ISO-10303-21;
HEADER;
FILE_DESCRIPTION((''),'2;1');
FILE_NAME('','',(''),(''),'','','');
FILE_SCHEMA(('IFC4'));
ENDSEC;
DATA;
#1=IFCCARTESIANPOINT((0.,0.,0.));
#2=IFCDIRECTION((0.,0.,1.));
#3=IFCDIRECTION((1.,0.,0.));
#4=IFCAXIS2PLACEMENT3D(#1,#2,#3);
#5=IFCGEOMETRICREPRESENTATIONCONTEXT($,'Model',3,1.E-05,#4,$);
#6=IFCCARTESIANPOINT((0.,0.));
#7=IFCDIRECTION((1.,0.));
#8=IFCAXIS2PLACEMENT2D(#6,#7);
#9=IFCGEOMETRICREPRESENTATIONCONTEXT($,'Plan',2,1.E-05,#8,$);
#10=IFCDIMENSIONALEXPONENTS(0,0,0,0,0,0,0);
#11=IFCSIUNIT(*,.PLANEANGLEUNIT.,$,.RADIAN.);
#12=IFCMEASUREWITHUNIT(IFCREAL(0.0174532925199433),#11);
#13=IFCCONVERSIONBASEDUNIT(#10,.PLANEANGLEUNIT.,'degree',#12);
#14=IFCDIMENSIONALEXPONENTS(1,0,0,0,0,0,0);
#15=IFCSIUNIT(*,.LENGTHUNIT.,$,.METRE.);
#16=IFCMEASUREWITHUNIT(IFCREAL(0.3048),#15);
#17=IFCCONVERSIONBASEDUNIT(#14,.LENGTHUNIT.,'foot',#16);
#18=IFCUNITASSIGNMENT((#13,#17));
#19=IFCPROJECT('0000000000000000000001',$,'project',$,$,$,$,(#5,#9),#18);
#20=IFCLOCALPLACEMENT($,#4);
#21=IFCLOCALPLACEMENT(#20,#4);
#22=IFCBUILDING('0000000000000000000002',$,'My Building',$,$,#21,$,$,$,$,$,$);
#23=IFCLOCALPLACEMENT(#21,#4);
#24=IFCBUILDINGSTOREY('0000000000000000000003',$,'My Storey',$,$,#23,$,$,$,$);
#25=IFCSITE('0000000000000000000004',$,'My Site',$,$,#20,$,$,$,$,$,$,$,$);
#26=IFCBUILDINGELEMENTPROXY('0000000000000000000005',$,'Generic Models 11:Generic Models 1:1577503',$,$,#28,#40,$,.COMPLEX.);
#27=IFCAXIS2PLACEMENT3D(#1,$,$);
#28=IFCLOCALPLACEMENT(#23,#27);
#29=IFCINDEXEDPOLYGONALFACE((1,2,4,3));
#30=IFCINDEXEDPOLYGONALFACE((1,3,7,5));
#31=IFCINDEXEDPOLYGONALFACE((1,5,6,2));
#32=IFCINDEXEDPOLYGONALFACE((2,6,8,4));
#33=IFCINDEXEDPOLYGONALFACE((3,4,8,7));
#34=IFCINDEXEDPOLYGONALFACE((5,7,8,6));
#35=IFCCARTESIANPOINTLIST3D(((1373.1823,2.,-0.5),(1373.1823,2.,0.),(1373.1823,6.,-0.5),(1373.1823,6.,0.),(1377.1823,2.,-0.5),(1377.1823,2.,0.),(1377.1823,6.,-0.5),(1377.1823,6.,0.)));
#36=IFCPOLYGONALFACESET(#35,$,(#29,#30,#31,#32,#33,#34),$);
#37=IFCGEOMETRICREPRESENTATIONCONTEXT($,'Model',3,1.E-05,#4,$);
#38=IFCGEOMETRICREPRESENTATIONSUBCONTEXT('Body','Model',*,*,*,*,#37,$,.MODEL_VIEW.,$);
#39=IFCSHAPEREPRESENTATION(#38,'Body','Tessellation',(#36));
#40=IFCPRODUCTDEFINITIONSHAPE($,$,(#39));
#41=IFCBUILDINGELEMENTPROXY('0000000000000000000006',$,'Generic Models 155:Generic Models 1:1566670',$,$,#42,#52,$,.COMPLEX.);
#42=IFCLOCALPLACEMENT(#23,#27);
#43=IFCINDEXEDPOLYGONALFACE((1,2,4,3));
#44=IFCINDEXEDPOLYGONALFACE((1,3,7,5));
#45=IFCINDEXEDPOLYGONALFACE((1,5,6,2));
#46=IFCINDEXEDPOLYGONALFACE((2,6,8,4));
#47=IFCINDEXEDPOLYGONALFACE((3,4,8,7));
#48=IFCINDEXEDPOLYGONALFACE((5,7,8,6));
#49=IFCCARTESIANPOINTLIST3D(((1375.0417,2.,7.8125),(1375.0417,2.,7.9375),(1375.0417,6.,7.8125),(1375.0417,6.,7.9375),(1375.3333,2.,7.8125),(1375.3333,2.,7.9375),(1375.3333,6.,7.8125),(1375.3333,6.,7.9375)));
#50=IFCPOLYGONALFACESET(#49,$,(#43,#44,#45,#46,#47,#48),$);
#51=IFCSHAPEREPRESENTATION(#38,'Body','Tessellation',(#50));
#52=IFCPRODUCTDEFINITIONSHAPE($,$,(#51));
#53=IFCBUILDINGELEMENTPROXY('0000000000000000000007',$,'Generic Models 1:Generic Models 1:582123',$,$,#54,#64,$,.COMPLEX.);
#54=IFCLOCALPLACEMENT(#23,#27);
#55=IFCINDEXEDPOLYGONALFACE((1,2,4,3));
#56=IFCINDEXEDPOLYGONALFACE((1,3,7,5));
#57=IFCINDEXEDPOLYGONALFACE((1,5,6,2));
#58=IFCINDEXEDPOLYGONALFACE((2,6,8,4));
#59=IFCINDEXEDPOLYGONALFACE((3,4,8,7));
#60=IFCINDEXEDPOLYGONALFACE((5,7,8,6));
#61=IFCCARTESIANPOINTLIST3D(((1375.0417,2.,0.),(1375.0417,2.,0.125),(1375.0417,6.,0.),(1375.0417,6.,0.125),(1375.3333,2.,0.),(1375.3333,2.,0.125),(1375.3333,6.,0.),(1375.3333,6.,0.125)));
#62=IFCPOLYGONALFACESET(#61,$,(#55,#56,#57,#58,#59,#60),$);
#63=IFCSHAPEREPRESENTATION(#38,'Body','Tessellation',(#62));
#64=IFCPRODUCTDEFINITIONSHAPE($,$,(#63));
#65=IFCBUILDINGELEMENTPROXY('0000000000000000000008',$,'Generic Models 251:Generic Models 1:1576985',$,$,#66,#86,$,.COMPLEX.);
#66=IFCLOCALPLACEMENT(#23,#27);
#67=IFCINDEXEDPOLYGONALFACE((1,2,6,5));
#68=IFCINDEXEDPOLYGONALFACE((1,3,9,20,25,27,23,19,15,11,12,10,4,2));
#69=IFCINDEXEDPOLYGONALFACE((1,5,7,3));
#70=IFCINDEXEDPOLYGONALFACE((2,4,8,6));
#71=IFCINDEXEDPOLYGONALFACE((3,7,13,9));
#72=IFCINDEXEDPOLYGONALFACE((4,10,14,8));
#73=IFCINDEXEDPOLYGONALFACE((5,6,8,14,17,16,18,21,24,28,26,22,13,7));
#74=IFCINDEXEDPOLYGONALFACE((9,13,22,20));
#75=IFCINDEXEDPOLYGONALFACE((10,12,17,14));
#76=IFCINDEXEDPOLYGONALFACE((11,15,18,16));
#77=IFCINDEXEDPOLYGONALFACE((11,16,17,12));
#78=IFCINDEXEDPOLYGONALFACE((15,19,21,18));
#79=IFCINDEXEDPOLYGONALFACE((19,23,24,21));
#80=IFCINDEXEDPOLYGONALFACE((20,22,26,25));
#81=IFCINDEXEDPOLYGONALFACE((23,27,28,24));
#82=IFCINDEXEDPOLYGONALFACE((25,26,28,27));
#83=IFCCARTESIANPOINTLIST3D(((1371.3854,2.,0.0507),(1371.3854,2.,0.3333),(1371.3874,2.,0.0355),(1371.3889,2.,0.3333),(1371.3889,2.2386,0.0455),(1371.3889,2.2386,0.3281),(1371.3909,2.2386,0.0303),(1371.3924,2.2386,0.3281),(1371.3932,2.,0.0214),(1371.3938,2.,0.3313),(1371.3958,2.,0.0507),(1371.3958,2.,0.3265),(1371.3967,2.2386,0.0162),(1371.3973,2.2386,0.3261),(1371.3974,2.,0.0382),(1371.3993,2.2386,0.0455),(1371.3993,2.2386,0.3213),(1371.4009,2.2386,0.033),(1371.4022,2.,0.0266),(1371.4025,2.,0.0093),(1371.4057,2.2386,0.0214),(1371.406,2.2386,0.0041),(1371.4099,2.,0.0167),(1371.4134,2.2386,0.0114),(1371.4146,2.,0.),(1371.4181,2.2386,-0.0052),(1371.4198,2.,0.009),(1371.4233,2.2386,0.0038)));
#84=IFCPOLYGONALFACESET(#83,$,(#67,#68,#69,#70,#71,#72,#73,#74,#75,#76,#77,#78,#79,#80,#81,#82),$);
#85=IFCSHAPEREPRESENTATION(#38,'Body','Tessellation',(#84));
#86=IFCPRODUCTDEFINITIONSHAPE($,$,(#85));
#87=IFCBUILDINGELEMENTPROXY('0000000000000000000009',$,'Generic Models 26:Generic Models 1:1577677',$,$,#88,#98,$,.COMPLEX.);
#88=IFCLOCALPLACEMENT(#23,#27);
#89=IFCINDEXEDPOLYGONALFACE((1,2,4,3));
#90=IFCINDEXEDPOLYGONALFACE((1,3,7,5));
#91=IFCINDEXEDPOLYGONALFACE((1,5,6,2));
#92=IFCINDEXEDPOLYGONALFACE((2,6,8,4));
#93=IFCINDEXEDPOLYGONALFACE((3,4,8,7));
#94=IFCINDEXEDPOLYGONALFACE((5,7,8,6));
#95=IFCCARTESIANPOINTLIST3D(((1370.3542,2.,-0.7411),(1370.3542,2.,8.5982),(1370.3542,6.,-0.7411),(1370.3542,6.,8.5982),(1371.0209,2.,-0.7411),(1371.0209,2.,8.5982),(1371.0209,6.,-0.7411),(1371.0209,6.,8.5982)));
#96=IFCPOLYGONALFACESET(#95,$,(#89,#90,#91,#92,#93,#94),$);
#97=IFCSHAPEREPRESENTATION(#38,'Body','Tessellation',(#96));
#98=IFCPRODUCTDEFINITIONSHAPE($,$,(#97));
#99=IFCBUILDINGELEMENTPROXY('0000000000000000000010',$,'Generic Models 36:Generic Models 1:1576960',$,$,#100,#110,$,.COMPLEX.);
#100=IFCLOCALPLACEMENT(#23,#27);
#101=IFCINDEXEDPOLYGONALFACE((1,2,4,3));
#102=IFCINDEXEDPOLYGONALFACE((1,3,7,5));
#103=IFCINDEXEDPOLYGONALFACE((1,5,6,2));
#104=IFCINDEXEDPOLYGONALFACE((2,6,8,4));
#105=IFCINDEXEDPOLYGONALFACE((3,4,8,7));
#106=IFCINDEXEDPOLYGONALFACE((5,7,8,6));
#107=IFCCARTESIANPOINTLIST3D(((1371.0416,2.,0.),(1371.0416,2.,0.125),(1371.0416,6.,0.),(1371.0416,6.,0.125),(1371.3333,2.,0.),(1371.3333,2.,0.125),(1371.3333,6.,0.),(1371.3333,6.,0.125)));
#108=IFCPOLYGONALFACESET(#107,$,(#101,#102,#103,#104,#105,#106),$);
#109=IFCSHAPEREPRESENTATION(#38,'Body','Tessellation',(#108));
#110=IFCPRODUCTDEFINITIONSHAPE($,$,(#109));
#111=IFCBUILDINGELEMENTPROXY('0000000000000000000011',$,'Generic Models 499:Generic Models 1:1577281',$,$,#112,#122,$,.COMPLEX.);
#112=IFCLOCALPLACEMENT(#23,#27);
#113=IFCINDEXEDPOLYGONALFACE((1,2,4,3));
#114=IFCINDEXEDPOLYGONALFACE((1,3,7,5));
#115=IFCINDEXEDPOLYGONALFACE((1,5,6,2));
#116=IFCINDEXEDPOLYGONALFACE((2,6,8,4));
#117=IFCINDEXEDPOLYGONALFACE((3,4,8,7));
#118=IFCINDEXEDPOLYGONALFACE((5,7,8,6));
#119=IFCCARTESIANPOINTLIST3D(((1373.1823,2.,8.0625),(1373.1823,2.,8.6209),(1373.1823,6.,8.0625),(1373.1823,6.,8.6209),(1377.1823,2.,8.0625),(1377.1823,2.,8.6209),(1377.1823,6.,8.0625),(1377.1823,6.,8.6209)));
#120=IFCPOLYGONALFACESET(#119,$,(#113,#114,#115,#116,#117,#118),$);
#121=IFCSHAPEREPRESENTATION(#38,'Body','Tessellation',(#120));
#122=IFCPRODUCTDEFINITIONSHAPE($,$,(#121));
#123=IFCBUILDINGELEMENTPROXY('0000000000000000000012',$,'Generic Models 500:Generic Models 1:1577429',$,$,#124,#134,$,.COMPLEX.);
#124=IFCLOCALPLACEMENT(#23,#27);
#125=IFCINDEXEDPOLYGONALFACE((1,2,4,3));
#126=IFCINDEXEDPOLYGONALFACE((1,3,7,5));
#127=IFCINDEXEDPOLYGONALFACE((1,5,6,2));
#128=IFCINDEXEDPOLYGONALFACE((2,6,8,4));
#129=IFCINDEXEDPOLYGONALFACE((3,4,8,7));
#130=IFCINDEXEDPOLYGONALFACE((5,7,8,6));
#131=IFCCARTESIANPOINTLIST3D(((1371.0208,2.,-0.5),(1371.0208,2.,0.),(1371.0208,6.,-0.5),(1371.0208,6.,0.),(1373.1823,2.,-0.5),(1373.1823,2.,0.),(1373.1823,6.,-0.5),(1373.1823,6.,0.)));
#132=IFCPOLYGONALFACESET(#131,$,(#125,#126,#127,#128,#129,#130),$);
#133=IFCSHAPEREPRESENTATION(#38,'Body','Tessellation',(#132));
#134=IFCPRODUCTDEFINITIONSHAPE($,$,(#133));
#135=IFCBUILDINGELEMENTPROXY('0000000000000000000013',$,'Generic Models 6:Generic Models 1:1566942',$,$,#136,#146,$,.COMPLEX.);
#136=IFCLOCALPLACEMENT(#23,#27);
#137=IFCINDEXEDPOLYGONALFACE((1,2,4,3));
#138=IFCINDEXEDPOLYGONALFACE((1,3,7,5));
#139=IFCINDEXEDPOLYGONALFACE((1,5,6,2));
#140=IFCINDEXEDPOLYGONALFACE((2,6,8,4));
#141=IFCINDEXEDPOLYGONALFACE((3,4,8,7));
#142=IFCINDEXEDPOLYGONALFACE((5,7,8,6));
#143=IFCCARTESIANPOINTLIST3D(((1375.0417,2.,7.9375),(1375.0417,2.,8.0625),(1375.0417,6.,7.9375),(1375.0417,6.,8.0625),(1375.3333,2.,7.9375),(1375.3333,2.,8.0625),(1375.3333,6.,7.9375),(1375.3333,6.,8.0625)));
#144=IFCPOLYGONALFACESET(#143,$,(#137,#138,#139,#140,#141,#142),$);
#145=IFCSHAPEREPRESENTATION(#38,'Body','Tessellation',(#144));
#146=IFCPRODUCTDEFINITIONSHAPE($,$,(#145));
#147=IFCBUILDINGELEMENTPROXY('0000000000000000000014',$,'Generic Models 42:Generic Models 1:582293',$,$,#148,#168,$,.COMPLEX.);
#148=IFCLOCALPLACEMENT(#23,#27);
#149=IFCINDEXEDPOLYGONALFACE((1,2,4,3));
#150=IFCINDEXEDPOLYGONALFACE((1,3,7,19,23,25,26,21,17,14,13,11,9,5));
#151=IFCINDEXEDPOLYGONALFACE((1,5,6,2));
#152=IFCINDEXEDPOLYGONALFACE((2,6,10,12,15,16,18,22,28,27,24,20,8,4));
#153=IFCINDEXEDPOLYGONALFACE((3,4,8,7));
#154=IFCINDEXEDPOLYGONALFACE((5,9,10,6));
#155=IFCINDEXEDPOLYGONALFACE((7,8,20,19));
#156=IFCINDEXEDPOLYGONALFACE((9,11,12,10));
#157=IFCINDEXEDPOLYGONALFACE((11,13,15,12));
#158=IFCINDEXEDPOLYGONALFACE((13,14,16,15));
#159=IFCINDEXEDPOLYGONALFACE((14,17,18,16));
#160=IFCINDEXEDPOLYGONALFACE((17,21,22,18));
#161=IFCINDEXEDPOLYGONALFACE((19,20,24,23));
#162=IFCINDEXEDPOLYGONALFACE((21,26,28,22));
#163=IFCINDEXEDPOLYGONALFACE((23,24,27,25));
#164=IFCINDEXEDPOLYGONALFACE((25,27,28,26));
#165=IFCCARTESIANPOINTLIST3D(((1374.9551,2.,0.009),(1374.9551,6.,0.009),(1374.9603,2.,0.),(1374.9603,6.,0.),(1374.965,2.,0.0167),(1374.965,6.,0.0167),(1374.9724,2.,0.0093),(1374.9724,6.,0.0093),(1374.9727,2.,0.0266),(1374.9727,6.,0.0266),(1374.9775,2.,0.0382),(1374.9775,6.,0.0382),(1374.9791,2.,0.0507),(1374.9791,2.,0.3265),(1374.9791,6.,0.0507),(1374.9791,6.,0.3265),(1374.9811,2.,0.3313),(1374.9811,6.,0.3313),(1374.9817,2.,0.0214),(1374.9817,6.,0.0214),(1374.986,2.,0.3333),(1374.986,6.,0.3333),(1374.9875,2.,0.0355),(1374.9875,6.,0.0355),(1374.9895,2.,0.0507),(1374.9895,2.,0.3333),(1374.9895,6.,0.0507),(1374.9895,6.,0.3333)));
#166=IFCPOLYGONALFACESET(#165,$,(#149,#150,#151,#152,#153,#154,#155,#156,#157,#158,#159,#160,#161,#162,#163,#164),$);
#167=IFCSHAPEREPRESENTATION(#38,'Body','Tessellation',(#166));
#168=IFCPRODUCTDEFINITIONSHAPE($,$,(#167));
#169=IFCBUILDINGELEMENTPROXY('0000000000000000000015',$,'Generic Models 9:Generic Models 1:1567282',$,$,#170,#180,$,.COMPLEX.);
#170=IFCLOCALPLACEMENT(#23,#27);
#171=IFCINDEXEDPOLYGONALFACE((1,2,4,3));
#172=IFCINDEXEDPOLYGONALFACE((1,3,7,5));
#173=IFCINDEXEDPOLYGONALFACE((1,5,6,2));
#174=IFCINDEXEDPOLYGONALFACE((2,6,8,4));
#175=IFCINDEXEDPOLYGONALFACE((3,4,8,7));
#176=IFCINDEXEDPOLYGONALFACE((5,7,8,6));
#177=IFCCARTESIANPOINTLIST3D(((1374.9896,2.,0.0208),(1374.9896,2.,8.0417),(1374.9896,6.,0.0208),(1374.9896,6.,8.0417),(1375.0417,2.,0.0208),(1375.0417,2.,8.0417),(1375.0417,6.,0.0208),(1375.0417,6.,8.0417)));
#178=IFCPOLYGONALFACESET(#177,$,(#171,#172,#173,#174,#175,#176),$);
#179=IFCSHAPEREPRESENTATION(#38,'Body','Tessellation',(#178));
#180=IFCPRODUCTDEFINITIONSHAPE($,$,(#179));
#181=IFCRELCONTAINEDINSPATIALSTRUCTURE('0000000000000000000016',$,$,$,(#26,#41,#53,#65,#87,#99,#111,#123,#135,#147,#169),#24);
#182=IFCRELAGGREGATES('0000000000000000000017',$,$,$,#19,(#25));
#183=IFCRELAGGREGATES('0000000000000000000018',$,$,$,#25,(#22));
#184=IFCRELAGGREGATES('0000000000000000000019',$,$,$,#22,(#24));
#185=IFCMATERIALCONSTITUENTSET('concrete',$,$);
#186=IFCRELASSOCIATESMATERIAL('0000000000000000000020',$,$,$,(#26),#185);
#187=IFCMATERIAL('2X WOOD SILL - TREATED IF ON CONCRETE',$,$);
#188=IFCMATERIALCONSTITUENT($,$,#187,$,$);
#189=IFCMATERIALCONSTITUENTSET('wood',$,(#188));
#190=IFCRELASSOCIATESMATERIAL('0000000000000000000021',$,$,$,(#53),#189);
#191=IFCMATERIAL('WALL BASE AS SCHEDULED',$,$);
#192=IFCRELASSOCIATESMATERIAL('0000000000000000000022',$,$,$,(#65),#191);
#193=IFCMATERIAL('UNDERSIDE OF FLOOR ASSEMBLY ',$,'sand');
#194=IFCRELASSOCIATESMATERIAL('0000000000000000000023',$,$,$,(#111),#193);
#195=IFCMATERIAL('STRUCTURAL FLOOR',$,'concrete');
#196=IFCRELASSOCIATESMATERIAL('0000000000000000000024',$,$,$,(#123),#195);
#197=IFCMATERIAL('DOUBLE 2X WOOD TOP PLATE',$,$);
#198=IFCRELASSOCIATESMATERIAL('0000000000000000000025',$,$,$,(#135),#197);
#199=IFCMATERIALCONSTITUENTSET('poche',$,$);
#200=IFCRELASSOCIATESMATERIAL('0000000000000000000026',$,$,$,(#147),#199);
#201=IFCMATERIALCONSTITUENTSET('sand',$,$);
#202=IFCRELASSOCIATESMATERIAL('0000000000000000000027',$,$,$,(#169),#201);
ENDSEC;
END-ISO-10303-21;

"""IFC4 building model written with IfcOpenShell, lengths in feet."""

from ifc_helpers import new_model, entity, si_unit, converted_unit, frame, origin_with_axes, origin_2d_with_axis, place, context, subcontext, project, spatial, polyline, outline, extrude, material, constituent, constituent_set, element, save


model = new_model("IFC4")

# Units and contexts
model_context_1 = context("Model", 3, precision=1e-05, world=origin_with_axes())
plan_context = context("Plan", 2, precision=1e-05, world=origin_2d_with_axis())
model_context_2 = context("Model", 3, precision=1e-05, world=origin_with_axes())
body_context = subcontext(model_context_2, "Body", "Model", "MODEL_VIEW")
ifc_project = project(units=[converted_unit("PLANEANGLEUNIT", "degree", entity("IfcReal", 0.0174532925199433), si_unit("PLANEANGLEUNIT", "RADIAN"), dimensions=[0, 0, 0, 0, 0, 0, 0]), converted_unit("LENGTHUNIT", "foot", entity("IfcReal", 0.3048), si_unit("LENGTHUNIT", "METRE"), dimensions=[1, 0, 0, 0, 0, 0, 0])], contexts=[model_context_1, plan_context])

# Site, building, storey
site_placement = place(None, origin_with_axes())
site = spatial("IfcSite", under=ifc_project, at=site_placement, Name="My Site")
building_placement = place(site_placement, origin_with_axes())
building = spatial("IfcBuilding", under=site, at=building_placement, Name="My Building")
storey_placement = place(building_placement, origin_with_axes())
storey = spatial("IfcBuildingStorey", under=building, at=storey_placement, Name="My Storey")

# Building element proxies
ifc_constituent_set_1 = constituent_set(Name="concrete")
proxy_1_placement = place(storey_placement, frame((1373.1823, 6.0, -0.5), z_axis=(0.0, -1.0, 0.0), x_axis=(0.0, 0.0, -1.0)))
element("IfcBuildingElementProxy", 1, at=proxy_1_placement, inside=storey, material=ifc_constituent_set_1, Name="Generic Models 11:Generic Models 1:1577503", PredefinedType="COMPLEX", context=body_context, shape_type="SweptSolid", body=[
    extrude(outline(polyline([(-0.25, -2.0), (0.25, -2.0), (0.25, 2.0), (-0.25, 2.0), (-0.25, -2.0)])), frame((-0.25, 2.0, 0.0), z_axis=(0.0, 0.0, -1.0), x_axis=(-1.0, 0.0, 0.0)), (0.0, 0.0, -1.0), 4.0),
])
proxy_2_placement = place(storey_placement, frame((1375.0417, 6.0, 7.8125), z_axis=(0.0, -1.0, 0.0), x_axis=(0.0, 0.0, -1.0)))
element("IfcBuildingElementProxy", 2, at=proxy_2_placement, inside=storey, Name="Generic Models 155:Generic Models 1:1566670", PredefinedType="COMPLEX", context=body_context, shape_type="SweptSolid", body=[
    extrude(outline(polyline([(-0.0625, -0.1458), (0.0625, -0.1458), (0.0625, 0.1458), (-0.0625, 0.1458), (-0.0625, -0.1458)])), frame((-0.0625, 0.1458, 0.0), z_axis=(0.0, 0.0, -1.0), x_axis=(-1.0, 0.0, 0.0)), (0.0, 0.0, -1.0), 4.0),
])
ifc_material_1 = material(Name="2X WOOD SILL - TREATED IF ON CONCRETE")
ifc_constituent_1 = constituent(ifc_material_1)
ifc_constituent_set_2 = constituent_set(constituents=[ifc_constituent_1], Name="wood")
proxy_3_placement = place(storey_placement, frame((1375.0417, 6.0, 0.0), z_axis=(0.0, -1.0, 0.0), x_axis=(0.0, 0.0, -1.0)))
element("IfcBuildingElementProxy", 3, at=proxy_3_placement, inside=storey, material=ifc_constituent_set_2, Name="Generic Models 1:Generic Models 1:582123", PredefinedType="COMPLEX", context=body_context, shape_type="SweptSolid", body=[
    extrude(outline(polyline([(-0.0625, -0.1458), (0.0625, -0.1458), (0.0625, 0.1458), (-0.0625, 0.1458), (-0.0625, -0.1458)])), frame((-0.0625, 0.1458, 0.0), z_axis=(0.0, 0.0, -1.0), x_axis=(1.0, 0.0, 0.0)), (0.0, 0.0, -1.0), 4.0),
])
ifc_material_2 = material(Name="WALL BASE AS SCHEDULED")
proxy_4_placement = place(storey_placement, frame((1371.3854, 6.0, 0.0), z_axis=(0.0, -1.0, 0.0), x_axis=(0.0, 0.0, -1.0)))
element("IfcBuildingElementProxy", 4, at=proxy_4_placement, inside=storey, material=ifc_material_2, Name="Generic Models 251:Generic Models 1:1576985", PredefinedType="COMPLEX", context=body_context, shape_type="SweptSolid", body=[
    extrude(outline(polyline([(0.0971, 0.0), (0.1059, -0.009), (0.1142, -0.0027), (0.1035, 0.0082), (0.0904, 0.016), (0.0756, 0.02), (0.0603, 0.0202), (-0.2202, -0.0144), (-0.2197, -0.0179), (-0.2172, -0.0225), (-0.2121, -0.0239), (0.0616, 0.0098), (0.0742, 0.0097), (0.0863, 0.0064), (0.0971, 0.0)])), frame((-0.1078, 0.0161, 3.7614), z_axis=(-0.000001, 0.0, -1.0), x_axis=(0.992503, 0.122219, -0.000004)), (-0.023549, 0.011857, -0.999652), 0.2387),
])
proxy_5_placement = place(storey_placement, frame((1370.3542, 6.0, -0.7411), z_axis=(0.0, -1.0, 0.0), x_axis=(0.0, 0.0, -1.0)))
element("IfcBuildingElementProxy", 5, at=proxy_5_placement, inside=storey, Name="Generic Models 26:Generic Models 1:1577677", PredefinedType="COMPLEX", context=body_context, shape_type="SweptSolid", body=[
    extrude(outline(polyline([(-0.3333, -4.6697), (0.3333, -4.6697), (0.3333, 4.6697), (-0.3333, 4.6697), (-0.3333, -4.6697)])), frame((-4.6697, 0.3333, 0.0), z_axis=(0.0, 0.0, -1.0), x_axis=(0.0, -1.0, 0.0)), (0.0, 0.0, -1.0), 4.0),
])
proxy_6_placement = place(storey_placement, frame((1371.0416, 6.0, 0.0), z_axis=(0.0, -1.0, 0.0), x_axis=(0.0, 0.0, -1.0)))
element("IfcBuildingElementProxy", 6, at=proxy_6_placement, inside=storey, Name="Generic Models 36:Generic Models 1:1576960", PredefinedType="COMPLEX", context=body_context, shape_type="SweptSolid", body=[
    extrude(outline(polyline([(-0.0625, -0.1458), (0.0625, -0.1458), (0.0625, 0.1458), (-0.0625, 0.1458), (-0.0625, -0.1458)])), frame((-0.0625, 0.1458, 0.0), z_axis=(0.0, 0.0, -1.0), x_axis=(1.0, 0.0, 0.0)), (0.0, 0.0, -1.0), 4.0),
])
ifc_material_3 = material(Name="UNDERSIDE OF FLOOR ASSEMBLY ", Category="sand")
proxy_7_placement = place(storey_placement, frame((1373.1823, 6.0, 8.0625), z_axis=(0.0, -1.0, 0.0), x_axis=(0.0, 0.0, -1.0)))
element("IfcBuildingElementProxy", 7, at=proxy_7_placement, inside=storey, material=ifc_material_3, Name="Generic Models 499:Generic Models 1:1577281", PredefinedType="COMPLEX", context=body_context, shape_type="SweptSolid", body=[
    extrude(outline(polyline([(-0.2792, -2.0), (0.2792, -2.0), (0.2792, 2.0), (-0.2792, 2.0), (-0.2792, -2.0)])), frame((-0.2792, 2.0, 0.0), z_axis=(0.0, 0.0, -1.0), x_axis=(1.0, 0.0, 0.0)), (0.0, 0.0, -1.0), 4.0),
])
ifc_material_4 = material(Name="STRUCTURAL FLOOR", Category="concrete")
proxy_8_placement = place(storey_placement, frame((1371.0208, 6.0, -0.5), z_axis=(0.0, -1.0, 0.0), x_axis=(0.0, 0.0, -1.0)))
element("IfcBuildingElementProxy", 8, at=proxy_8_placement, inside=storey, material=ifc_material_4, Name="Generic Models 500:Generic Models 1:1577429", PredefinedType="COMPLEX", context=body_context, shape_type="SweptSolid", body=[
    extrude(outline(polyline([(-0.25, -1.0807), (0.25, -1.0807), (0.25, 1.0807), (-0.25, 1.0807), (-0.25, -1.0807)])), frame((-0.25, 1.0807, 0.0), z_axis=(0.0, 0.0, -1.0), x_axis=(1.0, 0.0, 0.0)), (0.0, 0.0, -1.0), 4.0),
])
ifc_material_5 = material(Name="DOUBLE 2X WOOD TOP PLATE")
proxy_9_placement = place(storey_placement, frame((1375.0417, 6.0, 7.9375), z_axis=(0.0, -1.0, 0.0), x_axis=(0.0, 0.0, -1.0)))
element("IfcBuildingElementProxy", 9, at=proxy_9_placement, inside=storey, material=ifc_material_5, Name="Generic Models 6:Generic Models 1:1566942", PredefinedType="COMPLEX", context=body_context, shape_type="SweptSolid", body=[
    extrude(outline(polyline([(-0.0625, -0.1458), (0.0625, -0.1458), (0.0625, 0.1458), (-0.0625, 0.1458), (-0.0625, -0.1458)])), frame((-0.0625, 0.1458, 0.0), z_axis=(0.0, 0.0, -1.0), x_axis=(-1.0, 0.0, 0.0)), (0.0, 0.0, -1.0), 4.0),
])
ifc_constituent_set_3 = constituent_set(Name="poche")
proxy_10_placement = place(storey_placement, frame((1374.9551, 6.0, 0.0), z_axis=(0.0, -1.0, 0.0), x_axis=(0.0, 0.0, -1.0)))
element("IfcBuildingElementProxy", 10, at=proxy_10_placement, inside=storey, material=ifc_constituent_set_3, Name="Generic Models 42:Generic Models 1:582293", PredefinedType="COMPLEX", context=body_context, shape_type="SweptSolid", body=[
    extrude(outline(polyline([(0.0865, 0.0), (0.0747, -0.0042), (0.0622, -0.0053), (-0.2133, 0.0082), (-0.2182, 0.0064), (-0.2205, 0.0017), (-0.2206, -0.0019), (0.0617, -0.0157), (0.0769, -0.0144), (0.0913, -0.0093), (0.1038, -0.0006), (0.1137, 0.0111), (0.105, 0.0167), (0.0968, 0.0072), (0.0865, 0.0)])), frame((-0.113, 0.0218, 0.0), z_axis=(0.0, 0.0, -1.0), x_axis=(0.998808, -0.048806, 0.0)), (0.0, 0.0, -1.0), 4.0),
])
ifc_constituent_set_4 = constituent_set(Name="sand")
proxy_11_placement = place(storey_placement, frame((1374.9896, 6.0, 0.0208), z_axis=(0.0, -1.0, 0.0), x_axis=(0.0, 0.0, -1.0)))
element("IfcBuildingElementProxy", 11, at=proxy_11_placement, inside=storey, material=ifc_constituent_set_4, Name="Generic Models 9:Generic Models 1:1567282", PredefinedType="COMPLEX", context=body_context, shape_type="SweptSolid", body=[
    extrude(outline(polyline([(-0.026, -4.0104), (0.026, -4.0104), (0.026, 4.0104), (-0.026, 4.0104), (-0.026, -4.0104)])), frame((-4.0104, 0.026, 0.0), z_axis=(0.0, 0.0, -1.0), x_axis=(0.0, -1.0, 0.0)), (0.0, 0.0, -1.0), 4.0),
])

save(model, "model.ifc")
